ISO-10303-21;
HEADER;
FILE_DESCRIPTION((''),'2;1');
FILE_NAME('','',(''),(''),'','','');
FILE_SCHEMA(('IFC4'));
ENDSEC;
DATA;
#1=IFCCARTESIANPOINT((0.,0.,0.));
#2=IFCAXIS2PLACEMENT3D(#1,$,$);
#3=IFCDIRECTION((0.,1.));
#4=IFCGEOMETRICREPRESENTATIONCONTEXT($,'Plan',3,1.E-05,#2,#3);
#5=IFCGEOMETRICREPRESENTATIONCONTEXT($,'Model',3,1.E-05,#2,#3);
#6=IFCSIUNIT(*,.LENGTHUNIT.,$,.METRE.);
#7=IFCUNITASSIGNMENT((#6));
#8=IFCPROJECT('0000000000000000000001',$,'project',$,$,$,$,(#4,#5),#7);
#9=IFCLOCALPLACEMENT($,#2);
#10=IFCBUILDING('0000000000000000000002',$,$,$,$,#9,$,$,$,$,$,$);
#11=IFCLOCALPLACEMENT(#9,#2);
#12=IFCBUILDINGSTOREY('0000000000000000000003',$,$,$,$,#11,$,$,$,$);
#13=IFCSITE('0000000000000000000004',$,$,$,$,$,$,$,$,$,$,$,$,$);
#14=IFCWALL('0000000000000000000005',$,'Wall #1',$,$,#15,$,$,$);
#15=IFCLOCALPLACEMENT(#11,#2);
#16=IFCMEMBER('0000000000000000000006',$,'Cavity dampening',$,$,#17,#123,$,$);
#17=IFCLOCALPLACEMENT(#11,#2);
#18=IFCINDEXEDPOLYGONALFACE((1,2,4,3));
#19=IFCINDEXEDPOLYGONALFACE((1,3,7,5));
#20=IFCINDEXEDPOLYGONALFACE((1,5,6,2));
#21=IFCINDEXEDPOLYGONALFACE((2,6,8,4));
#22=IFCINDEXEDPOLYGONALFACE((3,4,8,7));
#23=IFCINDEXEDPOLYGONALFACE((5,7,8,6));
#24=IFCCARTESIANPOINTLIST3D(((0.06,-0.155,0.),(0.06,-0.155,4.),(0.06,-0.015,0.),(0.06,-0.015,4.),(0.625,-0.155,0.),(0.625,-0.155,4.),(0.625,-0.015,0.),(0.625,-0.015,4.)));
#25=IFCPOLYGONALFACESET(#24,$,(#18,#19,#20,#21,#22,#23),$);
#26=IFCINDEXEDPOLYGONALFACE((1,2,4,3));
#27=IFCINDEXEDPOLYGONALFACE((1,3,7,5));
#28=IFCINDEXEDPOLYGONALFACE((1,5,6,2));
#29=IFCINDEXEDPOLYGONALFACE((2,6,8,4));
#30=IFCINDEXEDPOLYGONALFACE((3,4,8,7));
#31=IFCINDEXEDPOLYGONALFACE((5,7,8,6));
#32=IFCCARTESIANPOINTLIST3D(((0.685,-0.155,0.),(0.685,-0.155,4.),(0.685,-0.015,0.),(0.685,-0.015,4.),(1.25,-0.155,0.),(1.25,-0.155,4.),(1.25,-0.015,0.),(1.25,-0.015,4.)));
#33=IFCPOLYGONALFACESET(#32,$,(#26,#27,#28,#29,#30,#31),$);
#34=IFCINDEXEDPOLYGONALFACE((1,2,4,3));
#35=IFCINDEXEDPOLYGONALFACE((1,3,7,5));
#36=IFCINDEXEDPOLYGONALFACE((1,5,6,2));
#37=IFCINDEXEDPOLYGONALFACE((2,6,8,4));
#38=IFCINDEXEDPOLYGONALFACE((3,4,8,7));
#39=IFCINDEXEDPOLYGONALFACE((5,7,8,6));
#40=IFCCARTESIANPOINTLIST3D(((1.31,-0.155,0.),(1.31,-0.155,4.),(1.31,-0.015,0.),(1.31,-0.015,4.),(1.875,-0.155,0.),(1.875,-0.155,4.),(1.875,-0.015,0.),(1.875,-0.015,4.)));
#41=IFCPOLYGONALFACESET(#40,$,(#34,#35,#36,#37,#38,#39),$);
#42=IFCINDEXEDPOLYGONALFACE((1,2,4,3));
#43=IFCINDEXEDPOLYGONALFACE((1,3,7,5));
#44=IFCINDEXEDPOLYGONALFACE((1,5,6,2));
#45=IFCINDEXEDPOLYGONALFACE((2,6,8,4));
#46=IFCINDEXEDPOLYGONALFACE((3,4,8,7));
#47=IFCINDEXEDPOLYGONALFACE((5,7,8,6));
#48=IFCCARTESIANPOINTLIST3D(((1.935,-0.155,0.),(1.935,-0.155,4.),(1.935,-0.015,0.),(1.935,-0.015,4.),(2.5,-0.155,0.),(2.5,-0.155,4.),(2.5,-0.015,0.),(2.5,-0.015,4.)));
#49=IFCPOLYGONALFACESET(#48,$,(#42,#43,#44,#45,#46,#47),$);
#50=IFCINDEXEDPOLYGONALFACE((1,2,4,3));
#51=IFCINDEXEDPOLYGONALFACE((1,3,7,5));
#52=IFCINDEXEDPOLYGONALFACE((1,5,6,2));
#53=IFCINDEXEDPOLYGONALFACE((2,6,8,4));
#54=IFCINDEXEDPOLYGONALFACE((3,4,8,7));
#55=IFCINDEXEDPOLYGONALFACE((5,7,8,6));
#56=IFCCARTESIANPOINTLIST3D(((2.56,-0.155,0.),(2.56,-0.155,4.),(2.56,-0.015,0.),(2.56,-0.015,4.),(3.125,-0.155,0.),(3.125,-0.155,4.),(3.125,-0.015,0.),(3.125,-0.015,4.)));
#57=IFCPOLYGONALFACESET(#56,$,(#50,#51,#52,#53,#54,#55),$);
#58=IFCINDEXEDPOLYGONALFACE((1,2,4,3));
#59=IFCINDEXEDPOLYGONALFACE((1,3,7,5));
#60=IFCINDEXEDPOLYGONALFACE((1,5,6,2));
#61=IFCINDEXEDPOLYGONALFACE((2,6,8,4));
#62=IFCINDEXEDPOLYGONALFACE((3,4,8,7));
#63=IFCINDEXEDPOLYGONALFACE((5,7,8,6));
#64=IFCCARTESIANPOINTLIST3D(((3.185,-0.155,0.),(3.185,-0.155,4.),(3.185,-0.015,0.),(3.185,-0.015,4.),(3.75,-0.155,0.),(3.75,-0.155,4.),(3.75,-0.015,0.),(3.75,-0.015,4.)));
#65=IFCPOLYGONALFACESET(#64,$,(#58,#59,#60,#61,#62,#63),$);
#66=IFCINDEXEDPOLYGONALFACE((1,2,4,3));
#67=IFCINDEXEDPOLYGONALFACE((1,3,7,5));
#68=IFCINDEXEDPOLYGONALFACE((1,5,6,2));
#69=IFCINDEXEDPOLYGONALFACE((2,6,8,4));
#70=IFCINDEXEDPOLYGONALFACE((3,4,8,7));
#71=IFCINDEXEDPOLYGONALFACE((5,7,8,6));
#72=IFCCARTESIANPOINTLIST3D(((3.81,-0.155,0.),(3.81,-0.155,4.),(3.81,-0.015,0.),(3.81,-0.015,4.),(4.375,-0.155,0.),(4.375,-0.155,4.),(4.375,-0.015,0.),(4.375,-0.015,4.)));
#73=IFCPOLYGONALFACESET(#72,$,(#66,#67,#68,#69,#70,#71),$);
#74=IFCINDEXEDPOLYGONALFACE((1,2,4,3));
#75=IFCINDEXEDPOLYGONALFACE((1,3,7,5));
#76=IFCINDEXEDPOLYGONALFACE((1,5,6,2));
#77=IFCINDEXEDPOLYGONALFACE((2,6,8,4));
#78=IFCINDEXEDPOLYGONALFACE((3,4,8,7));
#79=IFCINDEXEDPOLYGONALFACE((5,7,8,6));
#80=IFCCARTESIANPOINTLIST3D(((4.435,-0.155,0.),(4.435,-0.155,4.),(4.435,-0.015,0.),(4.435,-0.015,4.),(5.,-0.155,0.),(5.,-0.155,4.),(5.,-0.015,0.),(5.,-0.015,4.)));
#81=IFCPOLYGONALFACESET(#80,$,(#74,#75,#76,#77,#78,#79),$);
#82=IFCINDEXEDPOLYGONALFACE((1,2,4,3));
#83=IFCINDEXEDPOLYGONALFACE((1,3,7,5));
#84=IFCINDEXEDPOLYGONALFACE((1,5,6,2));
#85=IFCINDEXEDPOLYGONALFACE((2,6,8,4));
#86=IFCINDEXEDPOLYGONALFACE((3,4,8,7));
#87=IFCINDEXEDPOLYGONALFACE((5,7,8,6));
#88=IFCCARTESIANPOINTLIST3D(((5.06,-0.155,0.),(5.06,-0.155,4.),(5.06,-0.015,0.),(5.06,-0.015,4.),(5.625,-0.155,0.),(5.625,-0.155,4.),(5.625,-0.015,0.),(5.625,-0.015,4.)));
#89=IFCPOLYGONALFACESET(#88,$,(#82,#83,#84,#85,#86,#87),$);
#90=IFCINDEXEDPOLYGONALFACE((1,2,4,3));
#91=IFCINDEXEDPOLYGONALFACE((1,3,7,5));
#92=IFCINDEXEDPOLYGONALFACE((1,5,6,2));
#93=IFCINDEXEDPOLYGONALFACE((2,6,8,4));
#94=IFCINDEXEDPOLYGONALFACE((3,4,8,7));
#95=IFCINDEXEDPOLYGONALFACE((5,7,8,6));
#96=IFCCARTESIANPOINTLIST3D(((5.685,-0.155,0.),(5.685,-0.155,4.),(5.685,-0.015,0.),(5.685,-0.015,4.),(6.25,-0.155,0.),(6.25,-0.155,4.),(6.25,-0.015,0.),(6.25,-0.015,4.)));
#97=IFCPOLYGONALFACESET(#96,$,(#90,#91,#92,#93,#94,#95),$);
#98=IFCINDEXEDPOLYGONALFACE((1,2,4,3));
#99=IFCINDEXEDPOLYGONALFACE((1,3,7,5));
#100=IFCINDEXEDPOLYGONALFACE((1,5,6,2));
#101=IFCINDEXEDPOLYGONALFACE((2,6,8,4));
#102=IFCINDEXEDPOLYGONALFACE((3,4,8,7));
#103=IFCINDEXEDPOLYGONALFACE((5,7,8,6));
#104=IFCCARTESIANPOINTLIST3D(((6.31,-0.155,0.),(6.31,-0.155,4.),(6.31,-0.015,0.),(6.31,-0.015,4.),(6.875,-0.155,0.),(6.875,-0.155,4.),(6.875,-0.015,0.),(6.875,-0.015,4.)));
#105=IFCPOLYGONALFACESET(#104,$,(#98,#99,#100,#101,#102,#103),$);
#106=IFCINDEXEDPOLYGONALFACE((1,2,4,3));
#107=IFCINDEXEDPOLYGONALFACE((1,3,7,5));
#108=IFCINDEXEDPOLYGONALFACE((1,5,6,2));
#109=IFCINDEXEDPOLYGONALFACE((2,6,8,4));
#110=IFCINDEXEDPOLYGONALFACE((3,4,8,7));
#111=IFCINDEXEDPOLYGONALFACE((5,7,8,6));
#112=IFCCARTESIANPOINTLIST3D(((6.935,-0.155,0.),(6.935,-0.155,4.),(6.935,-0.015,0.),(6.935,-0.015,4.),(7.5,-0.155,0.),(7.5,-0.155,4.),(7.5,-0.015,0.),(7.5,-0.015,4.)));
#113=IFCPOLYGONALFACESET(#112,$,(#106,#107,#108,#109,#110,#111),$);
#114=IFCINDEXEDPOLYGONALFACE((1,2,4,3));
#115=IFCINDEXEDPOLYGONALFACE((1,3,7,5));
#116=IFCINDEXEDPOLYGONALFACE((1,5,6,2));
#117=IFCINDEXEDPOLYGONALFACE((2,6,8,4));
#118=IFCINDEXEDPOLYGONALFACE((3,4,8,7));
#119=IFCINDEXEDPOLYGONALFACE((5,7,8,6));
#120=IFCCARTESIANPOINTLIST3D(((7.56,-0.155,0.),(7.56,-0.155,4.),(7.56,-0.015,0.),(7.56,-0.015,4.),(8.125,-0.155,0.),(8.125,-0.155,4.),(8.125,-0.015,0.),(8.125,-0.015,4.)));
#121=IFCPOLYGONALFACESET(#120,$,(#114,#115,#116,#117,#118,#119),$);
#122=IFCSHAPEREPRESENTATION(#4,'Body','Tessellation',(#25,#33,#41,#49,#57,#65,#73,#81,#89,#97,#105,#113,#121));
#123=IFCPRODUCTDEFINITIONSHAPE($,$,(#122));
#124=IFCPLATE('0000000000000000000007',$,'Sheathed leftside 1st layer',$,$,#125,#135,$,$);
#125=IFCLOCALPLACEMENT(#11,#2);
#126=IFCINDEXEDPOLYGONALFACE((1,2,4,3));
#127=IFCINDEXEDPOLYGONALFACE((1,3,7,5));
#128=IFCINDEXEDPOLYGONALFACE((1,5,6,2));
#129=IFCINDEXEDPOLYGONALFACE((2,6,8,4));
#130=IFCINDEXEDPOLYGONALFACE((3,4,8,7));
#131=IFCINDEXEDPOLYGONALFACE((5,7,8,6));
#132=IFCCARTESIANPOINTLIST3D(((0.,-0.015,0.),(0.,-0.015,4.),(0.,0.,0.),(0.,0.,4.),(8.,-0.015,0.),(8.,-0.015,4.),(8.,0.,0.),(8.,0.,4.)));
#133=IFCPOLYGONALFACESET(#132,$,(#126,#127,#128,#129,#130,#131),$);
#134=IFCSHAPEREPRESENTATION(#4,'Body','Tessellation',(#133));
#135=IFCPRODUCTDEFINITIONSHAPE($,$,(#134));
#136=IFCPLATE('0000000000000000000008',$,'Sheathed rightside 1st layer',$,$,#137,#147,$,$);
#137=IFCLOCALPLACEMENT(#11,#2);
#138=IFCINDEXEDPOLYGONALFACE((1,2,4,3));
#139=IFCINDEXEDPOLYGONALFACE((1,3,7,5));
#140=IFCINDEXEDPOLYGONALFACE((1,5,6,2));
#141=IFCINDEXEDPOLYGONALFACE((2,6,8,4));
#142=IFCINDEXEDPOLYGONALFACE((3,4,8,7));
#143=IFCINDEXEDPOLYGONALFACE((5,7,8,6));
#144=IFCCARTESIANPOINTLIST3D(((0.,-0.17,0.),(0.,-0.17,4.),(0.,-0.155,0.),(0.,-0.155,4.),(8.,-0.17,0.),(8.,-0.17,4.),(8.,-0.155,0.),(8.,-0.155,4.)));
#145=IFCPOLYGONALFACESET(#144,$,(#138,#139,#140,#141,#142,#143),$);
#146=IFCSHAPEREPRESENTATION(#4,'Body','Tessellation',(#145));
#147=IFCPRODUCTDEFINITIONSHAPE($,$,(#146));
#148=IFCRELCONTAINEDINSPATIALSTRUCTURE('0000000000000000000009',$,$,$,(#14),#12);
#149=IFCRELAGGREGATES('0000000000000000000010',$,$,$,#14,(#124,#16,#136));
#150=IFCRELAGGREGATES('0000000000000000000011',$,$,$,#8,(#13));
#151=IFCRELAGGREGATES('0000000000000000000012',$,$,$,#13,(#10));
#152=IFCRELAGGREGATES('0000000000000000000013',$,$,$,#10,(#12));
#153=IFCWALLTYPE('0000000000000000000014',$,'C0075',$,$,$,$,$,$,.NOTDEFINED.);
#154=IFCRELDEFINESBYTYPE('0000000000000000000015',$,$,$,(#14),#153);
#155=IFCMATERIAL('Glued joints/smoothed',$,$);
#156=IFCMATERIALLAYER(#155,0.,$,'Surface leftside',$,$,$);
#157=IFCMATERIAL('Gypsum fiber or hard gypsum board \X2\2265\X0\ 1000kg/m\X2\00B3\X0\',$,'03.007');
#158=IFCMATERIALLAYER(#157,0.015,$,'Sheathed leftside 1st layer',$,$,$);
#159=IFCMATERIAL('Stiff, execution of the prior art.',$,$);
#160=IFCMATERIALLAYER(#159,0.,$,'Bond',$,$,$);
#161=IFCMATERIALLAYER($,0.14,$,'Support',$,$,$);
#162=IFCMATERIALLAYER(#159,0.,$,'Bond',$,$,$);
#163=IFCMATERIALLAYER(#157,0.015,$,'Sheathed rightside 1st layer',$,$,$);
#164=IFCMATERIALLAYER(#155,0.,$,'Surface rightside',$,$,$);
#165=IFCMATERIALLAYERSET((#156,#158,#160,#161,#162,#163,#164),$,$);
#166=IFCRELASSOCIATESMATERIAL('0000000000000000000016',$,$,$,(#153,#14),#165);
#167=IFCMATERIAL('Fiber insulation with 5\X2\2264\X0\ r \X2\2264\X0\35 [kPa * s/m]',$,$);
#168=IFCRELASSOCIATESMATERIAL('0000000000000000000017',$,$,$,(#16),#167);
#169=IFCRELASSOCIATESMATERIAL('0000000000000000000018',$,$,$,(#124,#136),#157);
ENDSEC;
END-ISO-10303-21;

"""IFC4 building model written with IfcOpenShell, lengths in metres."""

from ifc_helpers import new_model, si_unit, direction, frame, frame_2d, origin, origin_with_axes, place, context, project, spatial, rectangle, extrude, material, layer, layer_set, type_object, element, aggregate, save


model = new_model("IFC4")

# Units and contexts
plan_context = context("Plan", 3, precision=1e-05, world=origin(), true_north=direction((0.0, 1.0)))
model_context = context("Model", 3, precision=1e-05, world=origin(), true_north=direction((0.0, 1.0)))
ifc_project = project(units=[si_unit("LENGTHUNIT", "METRE")], contexts=[plan_context, model_context])

# Site, building, storey
site = spatial("IfcSite", under=ifc_project)
building_placement = place(None, origin())
building = spatial("IfcBuilding", under=site, at=building_placement)
storey_placement = place(building_placement, origin())
storey = spatial("IfcBuildingStorey", under=building, at=storey_placement)

# Wall, member, plates
ifc_material_1 = material(Name="Glued joints/smoothed")
ifc_layer_1 = layer(ifc_material_1, 0.0, Name="Surface leftside")
ifc_material_2 = material(Name="Gypsum fiber or hard gypsum board ≥ 1000kg/m³", Category="03.007")
ifc_layer_2 = layer(ifc_material_2, 0.015, Name="Sheathed leftside 1st layer")
ifc_material_3 = material(Name="Stiff, execution of the prior art.")
ifc_layer_3 = layer(ifc_material_3, 0.0, Name="Bond")
ifc_layer_4 = layer(None, 0.14, Name="Support")
ifc_layer_5 = layer(ifc_material_3, 0.0, Name="Bond")
ifc_layer_6 = layer(ifc_material_2, 0.015, Name="Sheathed rightside 1st layer")
ifc_layer_7 = layer(ifc_material_1, 0.0, Name="Surface rightside")
ifc_layer_set = layer_set([ifc_layer_1, ifc_layer_2, ifc_layer_3, ifc_layer_4, ifc_layer_5, ifc_layer_6, ifc_layer_7])
wall_type = type_object("IfcWallType", Name="C0075", PredefinedType="NOTDEFINED", material=ifc_layer_set)
wall_placement = place(None, frame((0.0, 0.0, 0.0), z_axis=(0.0, -1.0, 0.0), x_axis=(1.0, 0.0, 0.0)))
wall = element("IfcWall", 1, at=wall_placement, inside=storey, type_object=wall_type, material=ifc_layer_set, Name="Wall #1")
ifc_material_4 = material(Name="Fiber insulation with 5≤ r ≤35 [kPa * s/m]")
member_1_placement = place(wall_placement, origin())
member_1 = element("IfcMember", 2, at=member_1_placement, material=ifc_material_4, Name="Cavity dampening", context=plan_context, shape_type="SweptSolid", body=[
    extrude(rectangle(XDim=0.565, YDim=0.14, at=frame_2d((0.2825, 0.07), x_axis=(1.0, 0.0))), frame((0.06, 4.0, 0.015), z_axis=(0.0, -1.0, 0.0), x_axis=(1.0, 0.0, 0.0)), (0.0, 0.0, 1.0), 4.0),
    extrude(rectangle(XDim=0.565, YDim=0.14, at=frame_2d((0.2825, 0.07), x_axis=(1.0, 0.0))), frame((0.685, 4.0, 0.015), z_axis=(0.0, -1.0, 0.0), x_axis=(1.0, 0.0, 0.0)), (0.0, 0.0, 1.0), 4.0),
    extrude(rectangle(XDim=0.565, YDim=0.14, at=frame_2d((0.2825, 0.07), x_axis=(1.0, 0.0))), frame((1.31, 4.0, 0.015), z_axis=(0.0, -1.0, 0.0), x_axis=(1.0, 0.0, 0.0)), (0.0, 0.0, 1.0), 4.0),
    extrude(rectangle(XDim=0.565, YDim=0.14, at=frame_2d((0.2825, 0.07), x_axis=(1.0, 0.0))), frame((1.935, 4.0, 0.015), z_axis=(0.0, -1.0, 0.0), x_axis=(1.0, 0.0, 0.0)), (0.0, 0.0, 1.0), 4.0),
    extrude(rectangle(XDim=0.565, YDim=0.14, at=frame_2d((0.2825, 0.07), x_axis=(1.0, 0.0))), frame((2.56, 4.0, 0.015), z_axis=(0.0, -1.0, 0.0), x_axis=(1.0, 0.0, 0.0)), (0.0, 0.0, 1.0), 4.0),
    extrude(rectangle(XDim=0.565, YDim=0.14, at=frame_2d((0.2825, 0.07), x_axis=(1.0, 0.0))), frame((3.185, 4.0, 0.015), z_axis=(0.0, -1.0, 0.0), x_axis=(1.0, 0.0, 0.0)), (0.0, 0.0, 1.0), 4.0),
    extrude(rectangle(XDim=0.565, YDim=0.14, at=frame_2d((0.2825, 0.07), x_axis=(1.0, 0.0))), frame((3.81, 4.0, 0.015), z_axis=(0.0, -1.0, 0.0), x_axis=(1.0, 0.0, 0.0)), (0.0, 0.0, 1.0), 4.0),
    extrude(rectangle(XDim=0.565, YDim=0.14, at=frame_2d((0.2825, 0.07), x_axis=(1.0, 0.0))), frame((4.435, 4.0, 0.015), z_axis=(0.0, -1.0, 0.0), x_axis=(1.0, 0.0, 0.0)), (0.0, 0.0, 1.0), 4.0),
    extrude(rectangle(XDim=0.565, YDim=0.14, at=frame_2d((0.2825, 0.07), x_axis=(1.0, 0.0))), frame((5.06, 4.0, 0.015), z_axis=(0.0, -1.0, 0.0), x_axis=(1.0, 0.0, 0.0)), (0.0, 0.0, 1.0), 4.0),
    extrude(rectangle(XDim=0.565, YDim=0.14, at=frame_2d((0.2825, 0.07), x_axis=(1.0, 0.0))), frame((5.685, 4.0, 0.015), z_axis=(0.0, -1.0, 0.0), x_axis=(1.0, 0.0, 0.0)), (0.0, 0.0, 1.0), 4.0),
    extrude(rectangle(XDim=0.565, YDim=0.14, at=frame_2d((0.2825, 0.07), x_axis=(1.0, 0.0))), frame((6.31, 4.0, 0.015), z_axis=(0.0, -1.0, 0.0), x_axis=(1.0, 0.0, 0.0)), (0.0, 0.0, 1.0), 4.0),
    extrude(rectangle(XDim=0.565, YDim=0.14, at=frame_2d((0.2825, 0.07), x_axis=(1.0, 0.0))), frame((6.935, 4.0, 0.015), z_axis=(0.0, -1.0, 0.0), x_axis=(1.0, 0.0, 0.0)), (0.0, 0.0, 1.0), 4.0),
    extrude(rectangle(XDim=0.565, YDim=0.14, at=frame_2d((0.2825, 0.07), x_axis=(1.0, 0.0))), frame((7.56, 4.0, 0.015), z_axis=(0.0, -1.0, 0.0), x_axis=(1.0, 0.0, 0.0)), (0.0, 0.0, 1.0), 4.0),
])
plate_1_placement = place(wall_placement, origin())
plate_1 = element("IfcPlate", 3, at=plate_1_placement, material=ifc_material_2, Name="Sheathed leftside 1st layer", context=plan_context, shape_type="SweptSolid", body=[
    extrude(rectangle(XDim=8.0, YDim=4.0, at=frame_2d((4.0, 2.0), x_axis=(1.0, 0.0))), origin_with_axes(), (0.0, 0.0, 1.0), 0.015),
])
plate_2_placement = place(wall_placement, origin())
plate_2 = element("IfcPlate", 4, at=plate_2_placement, material=ifc_material_2, Name="Sheathed rightside 1st layer", context=plan_context, shape_type="SweptSolid", body=[
    extrude(rectangle(XDim=8.0, YDim=4.0, at=frame_2d((4.0, 2.0), x_axis=(1.0, 0.0))), frame((0.0, 0.0, 0.155), z_axis=(0.0, 0.0, 1.0), x_axis=(1.0, 0.0, 0.0)), (0.0, 0.0, 1.0), 0.015),
])
aggregate(wall, [plate_1, member_1, plate_2])

save(model, "model.ifc")
